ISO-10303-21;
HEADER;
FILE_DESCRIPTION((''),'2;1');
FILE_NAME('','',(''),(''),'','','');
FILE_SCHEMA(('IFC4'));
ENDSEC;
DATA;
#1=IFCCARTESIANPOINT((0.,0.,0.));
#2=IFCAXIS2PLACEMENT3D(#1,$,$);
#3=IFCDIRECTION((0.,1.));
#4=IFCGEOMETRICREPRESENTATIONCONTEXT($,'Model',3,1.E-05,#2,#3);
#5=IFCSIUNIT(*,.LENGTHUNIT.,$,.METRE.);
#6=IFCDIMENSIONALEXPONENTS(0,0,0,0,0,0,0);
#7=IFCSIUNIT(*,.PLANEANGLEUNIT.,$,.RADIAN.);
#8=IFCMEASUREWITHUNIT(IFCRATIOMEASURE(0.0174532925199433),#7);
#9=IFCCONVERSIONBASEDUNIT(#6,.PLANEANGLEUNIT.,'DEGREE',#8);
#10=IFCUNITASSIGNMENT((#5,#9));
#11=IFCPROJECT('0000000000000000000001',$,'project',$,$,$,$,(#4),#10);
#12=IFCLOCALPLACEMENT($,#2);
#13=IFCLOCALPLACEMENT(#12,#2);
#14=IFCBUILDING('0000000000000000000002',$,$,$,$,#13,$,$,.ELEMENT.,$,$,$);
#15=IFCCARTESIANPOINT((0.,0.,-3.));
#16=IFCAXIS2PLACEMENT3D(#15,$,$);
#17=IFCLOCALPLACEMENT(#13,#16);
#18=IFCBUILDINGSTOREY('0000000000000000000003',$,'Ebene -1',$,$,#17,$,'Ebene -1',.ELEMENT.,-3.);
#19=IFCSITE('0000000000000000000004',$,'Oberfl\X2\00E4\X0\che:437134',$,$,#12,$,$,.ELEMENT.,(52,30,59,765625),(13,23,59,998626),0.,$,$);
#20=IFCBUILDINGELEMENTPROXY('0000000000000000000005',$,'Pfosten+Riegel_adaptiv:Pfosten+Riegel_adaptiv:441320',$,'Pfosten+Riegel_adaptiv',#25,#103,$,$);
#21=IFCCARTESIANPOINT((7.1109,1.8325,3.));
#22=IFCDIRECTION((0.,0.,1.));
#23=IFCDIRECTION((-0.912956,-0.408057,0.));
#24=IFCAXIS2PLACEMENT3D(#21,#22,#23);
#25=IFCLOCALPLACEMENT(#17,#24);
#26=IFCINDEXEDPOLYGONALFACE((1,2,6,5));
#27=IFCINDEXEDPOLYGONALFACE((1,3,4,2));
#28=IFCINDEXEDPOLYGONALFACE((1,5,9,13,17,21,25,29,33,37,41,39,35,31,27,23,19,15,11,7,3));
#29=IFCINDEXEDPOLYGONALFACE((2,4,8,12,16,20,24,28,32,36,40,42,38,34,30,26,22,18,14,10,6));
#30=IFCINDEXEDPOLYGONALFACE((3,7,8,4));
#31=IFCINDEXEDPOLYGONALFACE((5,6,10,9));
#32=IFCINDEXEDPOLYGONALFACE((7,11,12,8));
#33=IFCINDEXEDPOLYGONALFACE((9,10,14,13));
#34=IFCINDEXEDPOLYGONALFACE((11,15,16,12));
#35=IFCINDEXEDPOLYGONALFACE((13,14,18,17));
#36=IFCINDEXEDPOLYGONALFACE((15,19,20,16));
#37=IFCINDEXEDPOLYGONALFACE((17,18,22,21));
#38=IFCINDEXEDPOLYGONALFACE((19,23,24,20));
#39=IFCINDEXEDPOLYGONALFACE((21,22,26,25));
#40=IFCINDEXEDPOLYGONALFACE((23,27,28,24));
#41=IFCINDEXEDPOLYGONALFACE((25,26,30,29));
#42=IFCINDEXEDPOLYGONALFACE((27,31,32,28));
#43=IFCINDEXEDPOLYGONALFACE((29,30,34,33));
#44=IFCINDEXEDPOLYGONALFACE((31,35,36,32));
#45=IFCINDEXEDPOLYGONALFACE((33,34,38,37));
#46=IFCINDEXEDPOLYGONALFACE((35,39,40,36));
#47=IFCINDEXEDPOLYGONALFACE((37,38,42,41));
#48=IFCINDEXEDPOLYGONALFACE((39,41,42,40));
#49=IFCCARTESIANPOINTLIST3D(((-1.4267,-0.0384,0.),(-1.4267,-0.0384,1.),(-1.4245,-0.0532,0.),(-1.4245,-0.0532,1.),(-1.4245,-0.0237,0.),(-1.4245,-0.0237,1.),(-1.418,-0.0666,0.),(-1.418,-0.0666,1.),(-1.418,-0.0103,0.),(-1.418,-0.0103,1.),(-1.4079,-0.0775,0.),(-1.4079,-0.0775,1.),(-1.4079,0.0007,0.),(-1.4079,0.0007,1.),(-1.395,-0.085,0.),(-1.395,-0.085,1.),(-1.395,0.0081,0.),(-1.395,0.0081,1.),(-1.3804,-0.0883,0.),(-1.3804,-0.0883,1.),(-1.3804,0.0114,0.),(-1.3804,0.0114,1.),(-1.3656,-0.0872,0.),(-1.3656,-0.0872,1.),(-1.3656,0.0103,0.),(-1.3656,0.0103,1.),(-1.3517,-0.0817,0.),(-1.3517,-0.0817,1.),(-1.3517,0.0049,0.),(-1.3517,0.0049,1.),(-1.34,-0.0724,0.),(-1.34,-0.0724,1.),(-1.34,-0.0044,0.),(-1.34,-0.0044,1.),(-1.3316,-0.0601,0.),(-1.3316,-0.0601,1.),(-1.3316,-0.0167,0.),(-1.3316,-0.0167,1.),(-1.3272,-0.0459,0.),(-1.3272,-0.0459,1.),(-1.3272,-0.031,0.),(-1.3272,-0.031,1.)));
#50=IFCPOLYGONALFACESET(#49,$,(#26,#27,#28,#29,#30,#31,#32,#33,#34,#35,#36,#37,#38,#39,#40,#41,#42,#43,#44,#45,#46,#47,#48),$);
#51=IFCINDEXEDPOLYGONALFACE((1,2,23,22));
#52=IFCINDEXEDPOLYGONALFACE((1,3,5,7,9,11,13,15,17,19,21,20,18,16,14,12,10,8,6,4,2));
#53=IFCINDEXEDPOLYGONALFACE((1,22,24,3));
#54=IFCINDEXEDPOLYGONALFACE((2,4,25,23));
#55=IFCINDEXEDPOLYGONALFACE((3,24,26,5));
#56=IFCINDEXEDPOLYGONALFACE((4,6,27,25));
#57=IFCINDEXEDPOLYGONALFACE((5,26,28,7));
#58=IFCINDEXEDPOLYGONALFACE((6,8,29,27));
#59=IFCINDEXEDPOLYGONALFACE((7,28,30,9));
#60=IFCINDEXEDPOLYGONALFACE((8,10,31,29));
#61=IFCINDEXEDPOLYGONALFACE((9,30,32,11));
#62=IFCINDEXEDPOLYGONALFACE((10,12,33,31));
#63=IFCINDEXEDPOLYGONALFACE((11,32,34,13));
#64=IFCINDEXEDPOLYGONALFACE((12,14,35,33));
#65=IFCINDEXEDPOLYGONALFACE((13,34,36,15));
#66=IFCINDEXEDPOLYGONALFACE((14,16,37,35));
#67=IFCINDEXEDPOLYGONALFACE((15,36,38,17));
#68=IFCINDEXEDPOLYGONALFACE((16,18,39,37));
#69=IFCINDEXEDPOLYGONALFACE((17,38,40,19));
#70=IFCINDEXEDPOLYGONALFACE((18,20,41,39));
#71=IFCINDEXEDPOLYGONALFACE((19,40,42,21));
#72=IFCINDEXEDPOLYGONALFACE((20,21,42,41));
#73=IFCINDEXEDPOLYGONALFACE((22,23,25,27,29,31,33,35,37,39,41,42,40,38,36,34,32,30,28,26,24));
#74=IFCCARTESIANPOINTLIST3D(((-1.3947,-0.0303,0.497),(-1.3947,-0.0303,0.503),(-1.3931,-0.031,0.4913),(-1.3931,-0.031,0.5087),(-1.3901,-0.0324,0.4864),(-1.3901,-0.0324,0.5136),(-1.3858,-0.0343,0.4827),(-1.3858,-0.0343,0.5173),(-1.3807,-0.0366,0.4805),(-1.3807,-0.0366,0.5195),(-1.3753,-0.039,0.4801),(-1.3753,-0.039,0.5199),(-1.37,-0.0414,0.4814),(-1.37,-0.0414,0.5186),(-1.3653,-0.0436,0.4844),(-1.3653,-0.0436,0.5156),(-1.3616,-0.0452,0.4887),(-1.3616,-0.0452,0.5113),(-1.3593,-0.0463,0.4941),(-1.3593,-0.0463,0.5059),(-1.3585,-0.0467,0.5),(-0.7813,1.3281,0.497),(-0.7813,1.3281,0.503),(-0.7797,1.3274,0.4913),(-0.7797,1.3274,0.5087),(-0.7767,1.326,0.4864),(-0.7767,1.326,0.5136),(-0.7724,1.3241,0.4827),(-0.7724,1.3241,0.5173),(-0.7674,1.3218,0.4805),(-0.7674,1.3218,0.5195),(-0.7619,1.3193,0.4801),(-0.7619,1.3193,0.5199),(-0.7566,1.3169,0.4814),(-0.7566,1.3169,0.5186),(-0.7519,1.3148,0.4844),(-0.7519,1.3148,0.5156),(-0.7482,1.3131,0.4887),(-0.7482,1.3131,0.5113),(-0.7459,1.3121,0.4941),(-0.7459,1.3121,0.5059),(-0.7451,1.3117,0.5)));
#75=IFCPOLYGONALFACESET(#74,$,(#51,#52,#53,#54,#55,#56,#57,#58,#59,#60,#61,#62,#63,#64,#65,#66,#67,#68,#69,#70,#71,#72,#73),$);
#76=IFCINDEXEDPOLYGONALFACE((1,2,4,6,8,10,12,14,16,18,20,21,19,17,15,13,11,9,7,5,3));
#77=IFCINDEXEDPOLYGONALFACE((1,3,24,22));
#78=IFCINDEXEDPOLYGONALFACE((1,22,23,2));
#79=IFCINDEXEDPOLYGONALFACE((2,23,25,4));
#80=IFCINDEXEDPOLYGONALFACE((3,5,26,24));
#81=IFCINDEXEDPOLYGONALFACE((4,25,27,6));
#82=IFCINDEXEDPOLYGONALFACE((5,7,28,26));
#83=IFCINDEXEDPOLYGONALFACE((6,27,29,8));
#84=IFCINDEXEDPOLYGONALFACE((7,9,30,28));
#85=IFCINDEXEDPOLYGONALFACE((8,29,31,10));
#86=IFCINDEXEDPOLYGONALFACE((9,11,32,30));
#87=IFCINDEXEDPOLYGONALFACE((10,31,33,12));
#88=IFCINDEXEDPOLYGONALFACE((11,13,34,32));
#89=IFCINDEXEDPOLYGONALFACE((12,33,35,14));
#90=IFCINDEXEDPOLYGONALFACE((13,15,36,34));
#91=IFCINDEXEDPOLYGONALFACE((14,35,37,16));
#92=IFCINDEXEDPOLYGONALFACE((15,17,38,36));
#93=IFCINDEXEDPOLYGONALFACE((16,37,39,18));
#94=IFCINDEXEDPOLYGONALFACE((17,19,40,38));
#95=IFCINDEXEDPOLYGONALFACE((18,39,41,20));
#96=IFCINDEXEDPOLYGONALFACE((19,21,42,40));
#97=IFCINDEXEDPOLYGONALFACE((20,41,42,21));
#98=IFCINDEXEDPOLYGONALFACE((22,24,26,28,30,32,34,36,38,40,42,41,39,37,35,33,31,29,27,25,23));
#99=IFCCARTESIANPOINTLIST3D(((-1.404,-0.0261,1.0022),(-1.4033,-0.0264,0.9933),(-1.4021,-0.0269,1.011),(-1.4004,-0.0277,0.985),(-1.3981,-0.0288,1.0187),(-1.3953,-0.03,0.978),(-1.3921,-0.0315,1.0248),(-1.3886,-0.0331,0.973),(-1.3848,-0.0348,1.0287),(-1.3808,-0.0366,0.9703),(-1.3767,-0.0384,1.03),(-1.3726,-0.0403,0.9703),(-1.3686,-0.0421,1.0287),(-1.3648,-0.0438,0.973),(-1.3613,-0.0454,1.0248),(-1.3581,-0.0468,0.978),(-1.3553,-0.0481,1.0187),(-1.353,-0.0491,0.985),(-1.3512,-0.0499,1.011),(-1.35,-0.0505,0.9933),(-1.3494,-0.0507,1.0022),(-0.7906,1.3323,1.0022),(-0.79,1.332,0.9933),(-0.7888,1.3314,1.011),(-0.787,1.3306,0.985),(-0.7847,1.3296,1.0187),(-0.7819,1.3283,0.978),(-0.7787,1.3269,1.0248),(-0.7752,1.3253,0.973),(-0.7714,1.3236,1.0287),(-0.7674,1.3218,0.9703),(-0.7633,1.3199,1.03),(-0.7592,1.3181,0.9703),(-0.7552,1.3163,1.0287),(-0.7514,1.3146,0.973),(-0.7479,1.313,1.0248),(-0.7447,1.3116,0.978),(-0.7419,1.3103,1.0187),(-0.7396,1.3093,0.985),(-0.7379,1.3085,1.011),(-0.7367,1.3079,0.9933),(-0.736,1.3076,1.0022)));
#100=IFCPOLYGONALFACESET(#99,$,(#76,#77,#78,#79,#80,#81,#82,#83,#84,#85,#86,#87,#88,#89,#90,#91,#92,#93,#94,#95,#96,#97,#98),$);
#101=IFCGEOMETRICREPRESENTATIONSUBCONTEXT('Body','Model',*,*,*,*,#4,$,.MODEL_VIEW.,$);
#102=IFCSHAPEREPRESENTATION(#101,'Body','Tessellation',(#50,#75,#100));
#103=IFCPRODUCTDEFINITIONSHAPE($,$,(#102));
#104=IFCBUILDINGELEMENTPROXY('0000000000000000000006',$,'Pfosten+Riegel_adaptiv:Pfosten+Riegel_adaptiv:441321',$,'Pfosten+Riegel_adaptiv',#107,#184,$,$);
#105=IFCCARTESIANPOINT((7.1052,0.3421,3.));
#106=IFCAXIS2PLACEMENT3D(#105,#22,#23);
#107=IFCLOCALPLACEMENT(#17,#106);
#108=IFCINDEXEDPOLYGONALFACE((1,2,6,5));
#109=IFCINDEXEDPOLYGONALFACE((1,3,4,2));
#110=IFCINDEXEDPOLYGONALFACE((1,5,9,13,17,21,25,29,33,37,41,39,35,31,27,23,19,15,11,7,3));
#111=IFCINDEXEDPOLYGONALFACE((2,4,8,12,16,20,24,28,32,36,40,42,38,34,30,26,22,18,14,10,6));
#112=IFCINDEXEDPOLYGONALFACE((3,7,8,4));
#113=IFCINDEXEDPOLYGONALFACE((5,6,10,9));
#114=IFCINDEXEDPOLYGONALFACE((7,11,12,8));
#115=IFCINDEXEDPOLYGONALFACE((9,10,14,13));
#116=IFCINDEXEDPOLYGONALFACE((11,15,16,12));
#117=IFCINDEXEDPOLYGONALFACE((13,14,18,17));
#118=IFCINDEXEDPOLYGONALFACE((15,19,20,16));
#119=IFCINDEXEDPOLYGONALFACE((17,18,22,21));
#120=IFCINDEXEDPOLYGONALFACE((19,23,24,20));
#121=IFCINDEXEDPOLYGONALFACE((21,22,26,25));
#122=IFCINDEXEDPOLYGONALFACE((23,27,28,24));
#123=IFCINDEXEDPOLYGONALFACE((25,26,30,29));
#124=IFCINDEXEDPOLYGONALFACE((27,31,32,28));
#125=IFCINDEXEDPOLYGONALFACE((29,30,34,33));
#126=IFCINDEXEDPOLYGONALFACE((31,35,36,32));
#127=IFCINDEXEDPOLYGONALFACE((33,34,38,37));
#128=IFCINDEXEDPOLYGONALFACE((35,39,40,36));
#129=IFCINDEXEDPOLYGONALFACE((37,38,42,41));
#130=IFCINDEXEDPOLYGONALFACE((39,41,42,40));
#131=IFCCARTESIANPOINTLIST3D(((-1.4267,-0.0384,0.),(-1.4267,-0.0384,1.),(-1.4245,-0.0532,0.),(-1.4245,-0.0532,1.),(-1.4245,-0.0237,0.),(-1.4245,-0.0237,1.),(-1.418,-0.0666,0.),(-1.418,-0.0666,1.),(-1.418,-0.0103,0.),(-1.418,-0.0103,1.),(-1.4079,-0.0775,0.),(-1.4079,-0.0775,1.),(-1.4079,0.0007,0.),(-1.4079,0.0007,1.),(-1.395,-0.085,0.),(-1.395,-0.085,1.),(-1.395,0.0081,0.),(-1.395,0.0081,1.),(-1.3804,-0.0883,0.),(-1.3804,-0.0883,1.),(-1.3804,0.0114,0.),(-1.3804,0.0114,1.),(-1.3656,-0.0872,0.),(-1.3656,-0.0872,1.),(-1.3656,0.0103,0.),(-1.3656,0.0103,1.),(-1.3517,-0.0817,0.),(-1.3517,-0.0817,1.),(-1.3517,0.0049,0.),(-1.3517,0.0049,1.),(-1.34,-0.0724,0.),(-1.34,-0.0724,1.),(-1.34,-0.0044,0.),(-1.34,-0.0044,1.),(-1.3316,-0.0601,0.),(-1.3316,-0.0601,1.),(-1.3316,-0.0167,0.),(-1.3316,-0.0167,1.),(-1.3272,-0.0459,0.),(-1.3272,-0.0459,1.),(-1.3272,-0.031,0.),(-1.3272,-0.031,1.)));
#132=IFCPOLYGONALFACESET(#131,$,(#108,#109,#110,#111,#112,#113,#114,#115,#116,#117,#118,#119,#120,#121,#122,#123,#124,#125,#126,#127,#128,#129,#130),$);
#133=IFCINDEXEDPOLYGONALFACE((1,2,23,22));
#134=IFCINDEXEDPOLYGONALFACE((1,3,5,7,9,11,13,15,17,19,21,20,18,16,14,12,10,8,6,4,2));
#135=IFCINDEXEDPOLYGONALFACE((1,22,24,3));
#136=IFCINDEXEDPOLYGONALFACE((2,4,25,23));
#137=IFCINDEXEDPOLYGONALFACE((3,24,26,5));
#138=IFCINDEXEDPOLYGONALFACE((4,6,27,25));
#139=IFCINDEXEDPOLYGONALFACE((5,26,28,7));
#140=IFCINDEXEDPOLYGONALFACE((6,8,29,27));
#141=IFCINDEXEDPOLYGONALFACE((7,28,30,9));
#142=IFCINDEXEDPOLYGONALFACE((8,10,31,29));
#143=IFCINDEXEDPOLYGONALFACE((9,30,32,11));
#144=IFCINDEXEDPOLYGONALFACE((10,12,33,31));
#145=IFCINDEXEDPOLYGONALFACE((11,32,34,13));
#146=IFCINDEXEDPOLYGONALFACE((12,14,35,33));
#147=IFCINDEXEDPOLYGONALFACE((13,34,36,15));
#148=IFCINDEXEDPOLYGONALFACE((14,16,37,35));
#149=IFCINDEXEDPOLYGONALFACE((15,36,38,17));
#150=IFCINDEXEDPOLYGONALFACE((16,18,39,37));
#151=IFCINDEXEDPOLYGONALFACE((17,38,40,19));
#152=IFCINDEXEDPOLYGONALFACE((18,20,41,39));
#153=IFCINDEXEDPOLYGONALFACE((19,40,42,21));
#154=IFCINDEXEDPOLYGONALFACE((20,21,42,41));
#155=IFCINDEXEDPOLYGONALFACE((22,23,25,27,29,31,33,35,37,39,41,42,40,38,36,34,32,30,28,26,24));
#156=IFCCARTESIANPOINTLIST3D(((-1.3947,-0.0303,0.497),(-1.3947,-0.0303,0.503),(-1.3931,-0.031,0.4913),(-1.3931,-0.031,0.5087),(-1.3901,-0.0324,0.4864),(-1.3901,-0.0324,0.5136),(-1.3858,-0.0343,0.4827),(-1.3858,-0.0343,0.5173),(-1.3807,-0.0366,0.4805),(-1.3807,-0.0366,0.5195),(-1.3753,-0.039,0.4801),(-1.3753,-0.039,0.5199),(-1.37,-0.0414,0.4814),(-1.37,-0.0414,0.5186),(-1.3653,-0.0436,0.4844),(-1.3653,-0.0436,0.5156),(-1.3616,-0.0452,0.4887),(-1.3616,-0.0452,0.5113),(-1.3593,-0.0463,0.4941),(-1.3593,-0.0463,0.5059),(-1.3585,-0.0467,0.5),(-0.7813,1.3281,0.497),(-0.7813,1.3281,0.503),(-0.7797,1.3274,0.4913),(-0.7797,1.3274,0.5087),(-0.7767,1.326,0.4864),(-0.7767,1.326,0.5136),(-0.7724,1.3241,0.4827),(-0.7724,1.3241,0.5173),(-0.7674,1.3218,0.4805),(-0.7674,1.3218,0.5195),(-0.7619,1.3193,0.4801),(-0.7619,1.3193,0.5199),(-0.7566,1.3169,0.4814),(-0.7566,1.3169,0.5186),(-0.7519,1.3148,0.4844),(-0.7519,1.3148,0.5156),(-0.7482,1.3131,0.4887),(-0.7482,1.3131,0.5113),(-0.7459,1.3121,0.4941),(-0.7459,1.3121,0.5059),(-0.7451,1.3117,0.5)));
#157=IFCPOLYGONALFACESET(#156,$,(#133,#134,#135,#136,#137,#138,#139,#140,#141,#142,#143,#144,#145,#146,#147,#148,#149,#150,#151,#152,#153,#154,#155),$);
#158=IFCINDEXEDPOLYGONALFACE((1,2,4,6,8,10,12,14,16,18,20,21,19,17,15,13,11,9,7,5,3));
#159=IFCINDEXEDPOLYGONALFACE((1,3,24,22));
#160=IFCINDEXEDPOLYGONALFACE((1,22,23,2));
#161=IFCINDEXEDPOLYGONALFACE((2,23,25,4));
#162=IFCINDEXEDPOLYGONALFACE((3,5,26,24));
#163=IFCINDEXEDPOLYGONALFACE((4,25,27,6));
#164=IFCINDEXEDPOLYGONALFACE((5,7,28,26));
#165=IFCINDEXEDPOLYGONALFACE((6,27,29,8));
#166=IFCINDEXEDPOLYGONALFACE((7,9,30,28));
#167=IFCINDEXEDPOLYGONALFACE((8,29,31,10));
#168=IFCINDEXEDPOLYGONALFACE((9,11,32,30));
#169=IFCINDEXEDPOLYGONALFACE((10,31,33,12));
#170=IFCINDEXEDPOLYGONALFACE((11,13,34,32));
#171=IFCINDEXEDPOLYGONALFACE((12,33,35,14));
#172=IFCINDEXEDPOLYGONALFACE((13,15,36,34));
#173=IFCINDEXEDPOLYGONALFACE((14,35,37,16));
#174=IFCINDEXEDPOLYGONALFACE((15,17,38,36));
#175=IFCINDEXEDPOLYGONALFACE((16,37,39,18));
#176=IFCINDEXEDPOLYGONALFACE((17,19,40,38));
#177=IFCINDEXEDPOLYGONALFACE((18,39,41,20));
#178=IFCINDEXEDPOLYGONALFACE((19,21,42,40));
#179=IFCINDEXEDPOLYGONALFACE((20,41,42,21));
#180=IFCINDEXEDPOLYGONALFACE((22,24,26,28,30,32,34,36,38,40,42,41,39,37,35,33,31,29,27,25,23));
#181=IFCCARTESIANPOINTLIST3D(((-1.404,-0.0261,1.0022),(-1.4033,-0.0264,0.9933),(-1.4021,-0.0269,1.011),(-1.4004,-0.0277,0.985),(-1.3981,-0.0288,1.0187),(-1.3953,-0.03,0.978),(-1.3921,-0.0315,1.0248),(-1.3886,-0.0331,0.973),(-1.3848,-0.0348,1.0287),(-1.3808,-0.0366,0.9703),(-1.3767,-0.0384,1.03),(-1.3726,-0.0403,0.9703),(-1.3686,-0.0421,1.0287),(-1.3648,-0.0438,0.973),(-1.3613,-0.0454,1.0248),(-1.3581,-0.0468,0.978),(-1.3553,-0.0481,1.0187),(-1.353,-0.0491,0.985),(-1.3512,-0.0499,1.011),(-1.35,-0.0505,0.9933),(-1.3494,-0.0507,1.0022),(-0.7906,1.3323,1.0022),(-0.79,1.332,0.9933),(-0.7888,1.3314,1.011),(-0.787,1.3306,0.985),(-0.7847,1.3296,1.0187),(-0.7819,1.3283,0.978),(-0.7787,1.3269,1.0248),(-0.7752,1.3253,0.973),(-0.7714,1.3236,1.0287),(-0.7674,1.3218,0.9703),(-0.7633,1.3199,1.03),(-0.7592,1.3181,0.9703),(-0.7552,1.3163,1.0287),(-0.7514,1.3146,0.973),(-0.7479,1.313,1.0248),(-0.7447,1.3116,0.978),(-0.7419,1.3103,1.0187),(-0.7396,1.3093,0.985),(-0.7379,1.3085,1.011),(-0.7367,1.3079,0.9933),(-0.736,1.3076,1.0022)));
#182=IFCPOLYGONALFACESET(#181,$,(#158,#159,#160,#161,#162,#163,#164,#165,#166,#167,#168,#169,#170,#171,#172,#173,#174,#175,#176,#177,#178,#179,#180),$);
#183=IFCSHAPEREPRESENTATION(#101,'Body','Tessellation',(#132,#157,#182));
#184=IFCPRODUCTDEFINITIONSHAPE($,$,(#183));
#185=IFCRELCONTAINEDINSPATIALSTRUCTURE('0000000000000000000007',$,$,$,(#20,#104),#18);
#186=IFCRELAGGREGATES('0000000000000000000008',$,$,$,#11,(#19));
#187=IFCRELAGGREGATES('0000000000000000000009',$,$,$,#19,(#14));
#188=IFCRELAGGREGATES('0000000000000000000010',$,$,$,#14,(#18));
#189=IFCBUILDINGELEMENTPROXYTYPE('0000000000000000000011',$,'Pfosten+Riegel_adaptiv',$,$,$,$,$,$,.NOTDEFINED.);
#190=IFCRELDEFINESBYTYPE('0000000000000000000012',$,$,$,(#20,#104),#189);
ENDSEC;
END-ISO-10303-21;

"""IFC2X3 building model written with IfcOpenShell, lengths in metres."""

from ifc_helpers import new_model, entity, si_unit, converted_unit, direction, frame, frame_2d, origin, place, context, subcontext, project, spatial, circle, extrude, source, transform, mapped, type_object, type_shapes, element, save


model = new_model("IFC2X3")

# Units and contexts
model_context = context("Model", 3, precision=1e-05, world=origin(), true_north=direction((0.0, 1.0)))
body_context = subcontext(model_context, "Body", "Model", "MODEL_VIEW")
ifc_project = project(units=[si_unit("LENGTHUNIT", "METRE"), converted_unit("PLANEANGLEUNIT", "DEGREE", entity("IfcRatioMeasure", 0.0174532925199433), si_unit("PLANEANGLEUNIT", "RADIAN"), dimensions=[0, 0, 0, 0, 0, 0, 0])], contexts=[model_context])

# Site, building, storey
site_placement = place(None, origin())
site = spatial("IfcSite", under=ifc_project, at=site_placement, Name="Oberfläche:437134", CompositionType="ELEMENT", RefLatitude=(52, 30, 59, 765625), RefLongitude=(13, 23, 59, 998626), RefElevation=0.0)
building_placement = place(site_placement, origin())
building = spatial("IfcBuilding", under=site, at=building_placement, CompositionType="ELEMENT")
storey_placement = place(building_placement, frame((0.0, 0.0, -3.0)))
storey = spatial("IfcBuildingStorey", under=building, at=storey_placement, Name="Ebene -1", LongName="Ebene -1", CompositionType="ELEMENT", Elevation=-3.0)

# Building element proxies
building_element_proxy_type_1 = type_object("IfcBuildingElementProxyType", Name="Pfosten+Riegel_adaptiv", PredefinedType="NOTDEFINED")
shared_shape_1 = source(origin(), body_context, "Body", "SweptSolid", [
    extrude(circle(Radius=0.05, at=frame_2d((0.0, 0.0), x_axis=(1.0, 0.0))), frame((-1.3767, -0.0384, 0.0), z_axis=(0.0, 0.0, 1.0), x_axis=(-1.0, 0.0, 0.0)), (0.0, 0.0, 1.0), 1.0),
    extrude(circle(Radius=0.02, at=frame_2d((0.0, 0.0), x_axis=(1.0, 0.0))), frame((-1.3767, -0.0384, 0.5), z_axis=(0.411546, 0.911389, 0.0), x_axis=(0.911389, -0.411546, 0.0)), (0.0, 0.0, 1.0), 1.4904),
    extrude(circle(Radius=0.03, at=frame_2d((0.0, 0.0), x_axis=(1.0, 0.0))), frame((-1.3767, -0.0384, 1.0), z_axis=(0.411546, 0.911389, 0.0), x_axis=(0.0, 0.0, 1.0)), (0.0, 0.0, 1.0), 1.4904),
])
type_shapes(building_element_proxy_type_1, [shared_shape_1])
for number, where, z_axis, x_axis, name in (
    (1, (7.1109, 1.8325, 3.0), (0.0, 0.0, 1.0), (-0.912956, -0.408057, 0.0), "Pfosten+Riegel_adaptiv:Pfosten+Riegel_adaptiv:441320"),
    (2, (7.1052, 0.3421, 3.0), (0.0, 0.0, 1.0), (-0.912956, -0.408057, 0.0), "Pfosten+Riegel_adaptiv:Pfosten+Riegel_adaptiv:441321"),
):
    element("IfcBuildingElementProxy", number, at=place(storey_placement, frame(where, z_axis=z_axis, x_axis=x_axis)), inside=storey, type_object=building_element_proxy_type_1, Name=name, ObjectType="Pfosten+Riegel_adaptiv", context=body_context, shape_type="MappedRepresentation", body=[
        mapped(shared_shape_1, transform((0.0, 0.0, 0.0), scale=1.0)),
    ])

save(model, "model.ifc")
